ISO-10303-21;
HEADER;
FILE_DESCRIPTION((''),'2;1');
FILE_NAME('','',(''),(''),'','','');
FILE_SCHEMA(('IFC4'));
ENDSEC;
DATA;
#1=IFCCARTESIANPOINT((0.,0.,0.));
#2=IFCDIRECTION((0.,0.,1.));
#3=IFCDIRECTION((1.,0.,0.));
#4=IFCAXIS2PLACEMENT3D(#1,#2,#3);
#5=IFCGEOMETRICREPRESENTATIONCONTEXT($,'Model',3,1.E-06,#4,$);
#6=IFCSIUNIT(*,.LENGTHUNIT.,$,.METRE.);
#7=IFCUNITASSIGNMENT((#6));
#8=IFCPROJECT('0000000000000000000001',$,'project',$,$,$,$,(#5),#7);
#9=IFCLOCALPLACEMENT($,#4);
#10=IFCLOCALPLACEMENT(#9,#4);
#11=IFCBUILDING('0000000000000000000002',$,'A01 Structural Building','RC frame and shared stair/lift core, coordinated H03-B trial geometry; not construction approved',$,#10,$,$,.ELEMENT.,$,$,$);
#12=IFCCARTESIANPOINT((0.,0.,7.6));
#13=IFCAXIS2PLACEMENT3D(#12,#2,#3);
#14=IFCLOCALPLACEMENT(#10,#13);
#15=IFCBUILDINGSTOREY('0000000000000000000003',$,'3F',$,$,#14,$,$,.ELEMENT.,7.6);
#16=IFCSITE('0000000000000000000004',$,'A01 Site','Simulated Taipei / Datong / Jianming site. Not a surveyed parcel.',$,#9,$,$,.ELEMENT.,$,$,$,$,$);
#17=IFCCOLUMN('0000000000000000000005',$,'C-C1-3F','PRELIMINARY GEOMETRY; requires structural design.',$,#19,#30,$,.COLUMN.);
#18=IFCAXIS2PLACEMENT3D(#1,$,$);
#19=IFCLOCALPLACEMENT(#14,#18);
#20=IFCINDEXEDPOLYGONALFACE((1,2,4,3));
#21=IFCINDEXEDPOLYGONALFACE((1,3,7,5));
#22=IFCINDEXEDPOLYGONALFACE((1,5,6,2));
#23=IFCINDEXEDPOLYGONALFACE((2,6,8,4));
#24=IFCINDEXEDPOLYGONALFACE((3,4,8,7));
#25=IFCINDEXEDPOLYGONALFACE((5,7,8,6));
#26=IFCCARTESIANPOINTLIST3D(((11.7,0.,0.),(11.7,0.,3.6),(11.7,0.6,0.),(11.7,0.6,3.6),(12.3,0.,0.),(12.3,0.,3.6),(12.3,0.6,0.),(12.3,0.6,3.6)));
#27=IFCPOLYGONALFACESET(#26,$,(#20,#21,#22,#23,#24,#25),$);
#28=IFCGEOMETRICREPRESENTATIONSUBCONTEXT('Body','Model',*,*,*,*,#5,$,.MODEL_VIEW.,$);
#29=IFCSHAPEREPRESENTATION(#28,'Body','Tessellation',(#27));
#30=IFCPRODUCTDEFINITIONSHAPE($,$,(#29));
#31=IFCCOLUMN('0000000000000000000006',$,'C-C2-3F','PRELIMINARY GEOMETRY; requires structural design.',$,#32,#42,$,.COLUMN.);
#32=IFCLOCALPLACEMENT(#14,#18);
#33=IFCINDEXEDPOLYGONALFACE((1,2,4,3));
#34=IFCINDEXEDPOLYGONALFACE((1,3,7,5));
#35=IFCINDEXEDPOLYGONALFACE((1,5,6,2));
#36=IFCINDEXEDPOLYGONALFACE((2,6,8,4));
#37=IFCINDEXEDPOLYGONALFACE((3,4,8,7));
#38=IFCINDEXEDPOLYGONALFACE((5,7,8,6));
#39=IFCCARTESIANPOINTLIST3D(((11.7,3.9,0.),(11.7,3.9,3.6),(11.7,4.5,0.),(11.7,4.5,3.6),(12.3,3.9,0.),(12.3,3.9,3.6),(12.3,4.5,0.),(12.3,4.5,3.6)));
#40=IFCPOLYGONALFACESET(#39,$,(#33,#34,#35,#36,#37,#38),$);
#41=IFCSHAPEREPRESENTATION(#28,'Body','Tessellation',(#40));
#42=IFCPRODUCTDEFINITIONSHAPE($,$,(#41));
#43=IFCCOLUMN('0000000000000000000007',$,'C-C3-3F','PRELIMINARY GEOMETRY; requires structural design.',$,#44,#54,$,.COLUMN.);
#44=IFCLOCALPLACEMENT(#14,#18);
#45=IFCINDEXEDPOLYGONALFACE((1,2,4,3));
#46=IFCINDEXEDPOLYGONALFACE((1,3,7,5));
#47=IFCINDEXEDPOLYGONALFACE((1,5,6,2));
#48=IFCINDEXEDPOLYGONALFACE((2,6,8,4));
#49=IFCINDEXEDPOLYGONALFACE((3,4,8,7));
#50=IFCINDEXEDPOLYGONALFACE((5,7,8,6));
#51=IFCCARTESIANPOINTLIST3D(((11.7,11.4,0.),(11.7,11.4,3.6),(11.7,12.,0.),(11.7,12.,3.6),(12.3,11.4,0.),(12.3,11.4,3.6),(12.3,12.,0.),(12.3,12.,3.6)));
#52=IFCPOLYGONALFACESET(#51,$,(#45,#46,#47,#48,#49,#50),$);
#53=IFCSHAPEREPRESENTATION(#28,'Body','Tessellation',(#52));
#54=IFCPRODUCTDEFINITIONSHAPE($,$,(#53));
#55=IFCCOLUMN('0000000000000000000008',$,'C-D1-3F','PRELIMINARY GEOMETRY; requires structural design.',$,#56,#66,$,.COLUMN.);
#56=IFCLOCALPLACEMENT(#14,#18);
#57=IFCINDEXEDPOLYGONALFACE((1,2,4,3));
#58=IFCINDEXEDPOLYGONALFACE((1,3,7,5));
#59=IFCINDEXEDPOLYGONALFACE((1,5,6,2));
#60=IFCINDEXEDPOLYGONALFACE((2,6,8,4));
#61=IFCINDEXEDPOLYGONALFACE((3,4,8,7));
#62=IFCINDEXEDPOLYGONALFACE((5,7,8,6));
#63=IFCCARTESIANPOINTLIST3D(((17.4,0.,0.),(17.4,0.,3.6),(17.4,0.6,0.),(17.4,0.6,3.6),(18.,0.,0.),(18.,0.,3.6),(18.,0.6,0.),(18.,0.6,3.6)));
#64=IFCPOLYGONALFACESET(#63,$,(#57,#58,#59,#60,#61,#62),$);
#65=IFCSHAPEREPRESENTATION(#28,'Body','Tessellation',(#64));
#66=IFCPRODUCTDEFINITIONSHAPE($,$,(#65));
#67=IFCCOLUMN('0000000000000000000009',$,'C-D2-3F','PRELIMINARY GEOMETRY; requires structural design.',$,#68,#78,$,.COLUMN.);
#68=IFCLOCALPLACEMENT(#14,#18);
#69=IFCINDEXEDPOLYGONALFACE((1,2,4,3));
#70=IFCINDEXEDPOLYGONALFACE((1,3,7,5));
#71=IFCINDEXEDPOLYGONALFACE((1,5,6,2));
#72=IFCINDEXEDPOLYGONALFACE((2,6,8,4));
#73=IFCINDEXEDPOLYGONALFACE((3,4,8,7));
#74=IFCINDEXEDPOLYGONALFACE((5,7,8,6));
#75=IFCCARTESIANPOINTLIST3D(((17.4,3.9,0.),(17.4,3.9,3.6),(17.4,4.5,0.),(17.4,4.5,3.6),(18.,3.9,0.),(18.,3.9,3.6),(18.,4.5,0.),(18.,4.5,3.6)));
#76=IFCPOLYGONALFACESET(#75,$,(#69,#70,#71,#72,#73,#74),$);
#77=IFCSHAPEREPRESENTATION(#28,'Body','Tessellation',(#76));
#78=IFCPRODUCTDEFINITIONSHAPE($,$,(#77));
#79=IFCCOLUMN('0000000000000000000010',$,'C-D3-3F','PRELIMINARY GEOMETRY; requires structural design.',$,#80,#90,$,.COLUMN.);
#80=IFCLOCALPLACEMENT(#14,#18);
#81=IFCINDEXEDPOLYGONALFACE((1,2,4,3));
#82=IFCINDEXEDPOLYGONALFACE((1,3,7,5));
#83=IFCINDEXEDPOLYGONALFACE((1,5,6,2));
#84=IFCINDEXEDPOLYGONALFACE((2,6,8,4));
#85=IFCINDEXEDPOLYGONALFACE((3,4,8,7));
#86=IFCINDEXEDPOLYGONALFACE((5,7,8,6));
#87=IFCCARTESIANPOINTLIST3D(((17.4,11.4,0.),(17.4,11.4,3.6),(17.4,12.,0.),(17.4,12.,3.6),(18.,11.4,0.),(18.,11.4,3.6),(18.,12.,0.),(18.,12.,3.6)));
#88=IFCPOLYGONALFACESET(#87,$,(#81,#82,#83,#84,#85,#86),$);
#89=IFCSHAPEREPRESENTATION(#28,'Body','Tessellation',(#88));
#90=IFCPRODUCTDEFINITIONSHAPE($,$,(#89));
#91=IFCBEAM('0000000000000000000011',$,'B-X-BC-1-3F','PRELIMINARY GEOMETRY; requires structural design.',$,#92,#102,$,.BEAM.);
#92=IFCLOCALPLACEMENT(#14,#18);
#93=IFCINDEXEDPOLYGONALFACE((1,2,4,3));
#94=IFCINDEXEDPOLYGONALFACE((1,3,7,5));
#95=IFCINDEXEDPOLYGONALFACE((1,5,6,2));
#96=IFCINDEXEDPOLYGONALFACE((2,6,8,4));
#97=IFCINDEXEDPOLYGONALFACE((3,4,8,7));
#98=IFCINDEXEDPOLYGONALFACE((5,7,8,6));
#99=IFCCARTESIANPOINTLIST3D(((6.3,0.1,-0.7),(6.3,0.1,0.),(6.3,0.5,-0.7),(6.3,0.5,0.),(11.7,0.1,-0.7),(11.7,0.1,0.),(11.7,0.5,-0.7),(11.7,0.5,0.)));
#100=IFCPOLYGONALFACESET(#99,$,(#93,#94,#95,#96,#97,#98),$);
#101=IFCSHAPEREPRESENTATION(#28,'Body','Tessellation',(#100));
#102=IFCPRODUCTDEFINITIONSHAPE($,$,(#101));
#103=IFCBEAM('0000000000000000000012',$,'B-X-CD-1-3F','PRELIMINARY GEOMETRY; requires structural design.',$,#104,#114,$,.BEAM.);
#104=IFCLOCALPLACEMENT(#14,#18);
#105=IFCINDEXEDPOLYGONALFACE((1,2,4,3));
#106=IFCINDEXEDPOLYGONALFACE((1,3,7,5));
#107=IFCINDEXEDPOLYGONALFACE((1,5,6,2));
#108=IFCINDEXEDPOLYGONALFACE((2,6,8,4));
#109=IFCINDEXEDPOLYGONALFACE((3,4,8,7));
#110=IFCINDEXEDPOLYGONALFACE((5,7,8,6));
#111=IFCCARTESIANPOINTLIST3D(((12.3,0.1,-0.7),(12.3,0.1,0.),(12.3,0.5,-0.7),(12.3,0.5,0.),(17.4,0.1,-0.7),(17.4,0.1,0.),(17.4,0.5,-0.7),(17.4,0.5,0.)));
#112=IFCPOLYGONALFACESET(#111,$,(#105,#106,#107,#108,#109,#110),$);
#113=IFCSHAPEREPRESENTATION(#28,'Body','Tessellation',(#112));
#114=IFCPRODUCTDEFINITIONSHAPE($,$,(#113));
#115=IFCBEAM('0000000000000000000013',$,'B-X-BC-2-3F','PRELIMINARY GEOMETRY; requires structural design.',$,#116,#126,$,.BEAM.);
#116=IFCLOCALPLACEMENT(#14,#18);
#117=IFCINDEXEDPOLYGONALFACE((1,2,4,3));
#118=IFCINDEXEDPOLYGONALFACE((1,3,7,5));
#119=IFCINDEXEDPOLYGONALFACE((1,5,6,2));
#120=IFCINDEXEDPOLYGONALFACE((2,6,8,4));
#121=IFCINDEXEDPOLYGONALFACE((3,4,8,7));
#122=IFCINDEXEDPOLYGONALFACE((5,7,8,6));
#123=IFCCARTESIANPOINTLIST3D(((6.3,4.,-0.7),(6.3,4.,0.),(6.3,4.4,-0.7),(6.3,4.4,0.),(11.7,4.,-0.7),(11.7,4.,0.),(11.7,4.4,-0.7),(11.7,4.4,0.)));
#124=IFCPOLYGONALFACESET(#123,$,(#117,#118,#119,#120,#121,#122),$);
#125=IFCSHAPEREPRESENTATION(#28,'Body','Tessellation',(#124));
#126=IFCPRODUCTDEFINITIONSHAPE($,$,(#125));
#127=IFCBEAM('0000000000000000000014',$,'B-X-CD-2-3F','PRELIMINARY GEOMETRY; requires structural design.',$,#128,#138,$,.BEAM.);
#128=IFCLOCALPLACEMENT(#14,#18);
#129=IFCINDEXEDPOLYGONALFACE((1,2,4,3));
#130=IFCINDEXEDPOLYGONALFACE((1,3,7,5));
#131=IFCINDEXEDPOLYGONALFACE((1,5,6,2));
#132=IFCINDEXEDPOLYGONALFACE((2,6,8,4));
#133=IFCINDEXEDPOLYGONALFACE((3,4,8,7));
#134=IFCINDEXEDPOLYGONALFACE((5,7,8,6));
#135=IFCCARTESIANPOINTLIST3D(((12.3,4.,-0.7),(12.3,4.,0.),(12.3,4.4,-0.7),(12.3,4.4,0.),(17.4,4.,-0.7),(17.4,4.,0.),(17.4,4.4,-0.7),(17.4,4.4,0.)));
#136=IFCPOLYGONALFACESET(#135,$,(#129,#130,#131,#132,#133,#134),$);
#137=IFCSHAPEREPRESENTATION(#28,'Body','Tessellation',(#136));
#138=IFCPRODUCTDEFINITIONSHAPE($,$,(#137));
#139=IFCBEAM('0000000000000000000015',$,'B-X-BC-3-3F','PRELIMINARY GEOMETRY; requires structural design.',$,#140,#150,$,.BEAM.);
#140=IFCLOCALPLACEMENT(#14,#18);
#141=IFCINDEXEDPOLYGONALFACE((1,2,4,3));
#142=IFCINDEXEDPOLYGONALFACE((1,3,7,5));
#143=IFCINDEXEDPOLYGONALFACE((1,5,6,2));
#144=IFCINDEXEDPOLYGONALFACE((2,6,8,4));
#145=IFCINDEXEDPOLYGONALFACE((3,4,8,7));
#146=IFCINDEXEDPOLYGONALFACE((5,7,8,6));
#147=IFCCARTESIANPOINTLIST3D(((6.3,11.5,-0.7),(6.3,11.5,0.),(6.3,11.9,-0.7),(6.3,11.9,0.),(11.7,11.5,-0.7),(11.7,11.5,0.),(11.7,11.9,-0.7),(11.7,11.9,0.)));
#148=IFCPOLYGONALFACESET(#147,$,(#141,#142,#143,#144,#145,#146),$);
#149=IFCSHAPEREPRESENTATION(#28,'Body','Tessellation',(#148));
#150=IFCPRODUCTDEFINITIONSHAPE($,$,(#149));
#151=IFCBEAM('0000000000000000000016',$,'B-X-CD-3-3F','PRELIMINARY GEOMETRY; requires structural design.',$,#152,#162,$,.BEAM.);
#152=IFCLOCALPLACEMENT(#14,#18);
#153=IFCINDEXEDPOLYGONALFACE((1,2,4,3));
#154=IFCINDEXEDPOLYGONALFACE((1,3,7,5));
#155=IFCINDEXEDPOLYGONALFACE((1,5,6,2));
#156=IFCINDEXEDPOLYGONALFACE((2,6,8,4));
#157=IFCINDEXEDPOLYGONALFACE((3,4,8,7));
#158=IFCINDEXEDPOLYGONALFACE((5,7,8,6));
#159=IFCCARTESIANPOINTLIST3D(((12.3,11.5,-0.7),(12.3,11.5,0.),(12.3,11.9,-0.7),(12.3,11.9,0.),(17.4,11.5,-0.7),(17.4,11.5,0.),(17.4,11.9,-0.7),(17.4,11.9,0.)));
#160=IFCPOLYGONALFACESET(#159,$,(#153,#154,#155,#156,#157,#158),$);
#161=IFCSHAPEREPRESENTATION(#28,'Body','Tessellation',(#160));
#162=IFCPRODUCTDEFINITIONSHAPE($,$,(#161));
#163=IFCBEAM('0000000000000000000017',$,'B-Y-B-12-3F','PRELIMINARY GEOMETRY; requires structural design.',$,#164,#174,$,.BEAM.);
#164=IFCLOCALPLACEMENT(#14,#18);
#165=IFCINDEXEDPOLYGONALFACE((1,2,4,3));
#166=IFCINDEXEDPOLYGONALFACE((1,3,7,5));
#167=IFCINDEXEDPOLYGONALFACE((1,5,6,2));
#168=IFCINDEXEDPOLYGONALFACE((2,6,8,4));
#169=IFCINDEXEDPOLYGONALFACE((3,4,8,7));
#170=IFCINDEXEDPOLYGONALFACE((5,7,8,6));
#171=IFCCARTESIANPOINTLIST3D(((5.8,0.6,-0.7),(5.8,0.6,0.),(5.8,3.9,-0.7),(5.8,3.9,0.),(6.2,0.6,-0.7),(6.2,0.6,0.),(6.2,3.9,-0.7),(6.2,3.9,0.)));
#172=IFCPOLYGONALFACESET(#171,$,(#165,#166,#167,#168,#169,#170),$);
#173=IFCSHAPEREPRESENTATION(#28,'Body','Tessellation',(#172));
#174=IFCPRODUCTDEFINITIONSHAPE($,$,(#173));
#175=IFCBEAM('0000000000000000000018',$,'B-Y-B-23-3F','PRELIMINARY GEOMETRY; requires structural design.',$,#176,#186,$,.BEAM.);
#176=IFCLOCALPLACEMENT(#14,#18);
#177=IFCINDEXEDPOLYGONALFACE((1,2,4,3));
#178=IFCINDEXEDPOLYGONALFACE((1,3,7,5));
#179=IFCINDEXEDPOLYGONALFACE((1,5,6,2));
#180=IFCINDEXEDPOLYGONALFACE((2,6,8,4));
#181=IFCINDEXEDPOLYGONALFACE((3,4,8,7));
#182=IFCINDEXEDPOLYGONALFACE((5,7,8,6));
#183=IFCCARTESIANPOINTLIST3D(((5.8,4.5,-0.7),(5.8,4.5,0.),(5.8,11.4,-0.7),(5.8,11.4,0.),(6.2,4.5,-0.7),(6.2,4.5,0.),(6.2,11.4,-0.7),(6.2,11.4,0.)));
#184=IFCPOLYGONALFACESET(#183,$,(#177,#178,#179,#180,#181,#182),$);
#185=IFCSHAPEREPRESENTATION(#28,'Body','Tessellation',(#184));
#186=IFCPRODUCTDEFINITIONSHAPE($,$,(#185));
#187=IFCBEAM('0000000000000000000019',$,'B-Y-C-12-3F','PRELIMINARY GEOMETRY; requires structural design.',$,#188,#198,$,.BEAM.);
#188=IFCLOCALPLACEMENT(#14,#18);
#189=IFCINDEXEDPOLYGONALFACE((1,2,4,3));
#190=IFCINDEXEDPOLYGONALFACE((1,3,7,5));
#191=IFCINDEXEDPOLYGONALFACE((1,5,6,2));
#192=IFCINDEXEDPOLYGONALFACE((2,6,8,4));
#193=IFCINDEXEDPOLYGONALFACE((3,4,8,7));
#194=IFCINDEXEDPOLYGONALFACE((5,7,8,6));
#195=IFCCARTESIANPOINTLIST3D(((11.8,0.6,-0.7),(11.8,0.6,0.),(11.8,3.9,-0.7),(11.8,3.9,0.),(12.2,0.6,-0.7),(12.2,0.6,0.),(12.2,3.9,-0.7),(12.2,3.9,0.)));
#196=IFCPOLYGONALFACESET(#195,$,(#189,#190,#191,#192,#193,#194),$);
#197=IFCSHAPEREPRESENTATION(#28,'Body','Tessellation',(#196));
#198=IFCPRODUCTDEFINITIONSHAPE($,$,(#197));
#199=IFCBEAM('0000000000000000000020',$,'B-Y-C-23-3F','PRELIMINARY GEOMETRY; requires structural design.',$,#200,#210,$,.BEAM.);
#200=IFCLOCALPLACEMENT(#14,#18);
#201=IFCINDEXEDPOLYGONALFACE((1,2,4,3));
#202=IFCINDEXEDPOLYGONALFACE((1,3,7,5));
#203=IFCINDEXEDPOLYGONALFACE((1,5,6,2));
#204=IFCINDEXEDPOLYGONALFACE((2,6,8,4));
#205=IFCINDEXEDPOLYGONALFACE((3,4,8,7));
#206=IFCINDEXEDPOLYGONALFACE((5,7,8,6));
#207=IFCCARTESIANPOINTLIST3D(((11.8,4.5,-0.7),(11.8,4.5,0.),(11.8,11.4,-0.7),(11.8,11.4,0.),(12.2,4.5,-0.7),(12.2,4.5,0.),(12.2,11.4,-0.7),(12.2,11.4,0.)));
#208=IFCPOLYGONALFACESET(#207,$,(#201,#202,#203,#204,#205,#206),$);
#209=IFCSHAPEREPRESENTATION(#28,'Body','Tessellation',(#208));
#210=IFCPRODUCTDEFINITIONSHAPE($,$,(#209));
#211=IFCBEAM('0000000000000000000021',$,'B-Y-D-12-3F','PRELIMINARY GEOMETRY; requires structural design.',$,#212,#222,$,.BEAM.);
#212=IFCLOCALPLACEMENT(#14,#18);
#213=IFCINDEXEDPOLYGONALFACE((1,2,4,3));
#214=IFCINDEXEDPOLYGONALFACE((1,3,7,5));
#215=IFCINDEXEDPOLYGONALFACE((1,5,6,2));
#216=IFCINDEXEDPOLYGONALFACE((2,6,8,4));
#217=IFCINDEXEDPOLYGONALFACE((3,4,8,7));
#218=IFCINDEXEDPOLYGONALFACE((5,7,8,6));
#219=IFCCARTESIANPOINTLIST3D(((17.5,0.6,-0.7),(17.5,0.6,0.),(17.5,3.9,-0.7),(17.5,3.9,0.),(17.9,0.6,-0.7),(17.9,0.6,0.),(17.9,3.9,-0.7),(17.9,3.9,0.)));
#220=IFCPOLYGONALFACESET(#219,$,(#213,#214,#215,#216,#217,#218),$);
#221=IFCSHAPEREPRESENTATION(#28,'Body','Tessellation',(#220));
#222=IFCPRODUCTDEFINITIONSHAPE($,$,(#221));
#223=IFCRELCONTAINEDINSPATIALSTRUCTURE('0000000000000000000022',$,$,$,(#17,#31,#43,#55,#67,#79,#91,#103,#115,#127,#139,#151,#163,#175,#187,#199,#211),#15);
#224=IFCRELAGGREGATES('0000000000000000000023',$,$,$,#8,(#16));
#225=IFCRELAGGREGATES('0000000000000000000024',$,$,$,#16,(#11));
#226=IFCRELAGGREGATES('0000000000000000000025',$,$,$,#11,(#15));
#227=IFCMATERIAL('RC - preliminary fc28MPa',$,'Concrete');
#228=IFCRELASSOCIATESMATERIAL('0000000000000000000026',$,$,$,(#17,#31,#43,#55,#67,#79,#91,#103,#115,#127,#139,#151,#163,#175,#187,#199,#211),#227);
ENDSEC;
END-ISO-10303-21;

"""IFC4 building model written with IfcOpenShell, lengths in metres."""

from ifc_helpers import new_model, si_unit, frame, origin_with_axes, place, context, subcontext, project, spatial, rectangle, extrude, material, element, save


model = new_model("IFC4")

# Units and contexts
model_context = context("Model", 3, precision=1e-06, world=origin_with_axes())
body_context = subcontext(model_context, "Body", "Model", "MODEL_VIEW")
ifc_project = project(units=[si_unit("LENGTHUNIT", "METRE")], contexts=[model_context])

# Site, building, storey
site_placement = place(None, origin_with_axes())
site = spatial("IfcSite", under=ifc_project, at=site_placement, Name="A01 Site", Description="Simulated Taipei / Datong / Jianming site. Not a surveyed parcel.", CompositionType="ELEMENT")
building_placement = place(site_placement, origin_with_axes())
building = spatial("IfcBuilding", under=site, at=building_placement, Name="A01 Structural Building", Description="RC frame and shared stair/lift core, coordinated H03-B trial geometry; not construction approved", CompositionType="ELEMENT")
storey_placement = place(building_placement, frame((0.0, 0.0, 7.6), z_axis=(0.0, 0.0, 1.0), x_axis=(1.0, 0.0, 0.0)))
storey = spatial("IfcBuildingStorey", under=building, at=storey_placement, Name="3F", CompositionType="ELEMENT", Elevation=7.6)

# Columns
ifc_material = material(Name="RC - preliminary fc28MPa", Category="Concrete")
for number, where, z_axis, x_axis, name in (
    (1, (12.0, 0.3, 0.0), (0.0, 0.0, 1.0), (1.0, 0.0, 0.0), "C-C1-3F"),
    (2, (12.0, 4.2, 0.0), (0.0, 0.0, 1.0), (1.0, 0.0, 0.0), "C-C2-3F"),
    (3, (12.0, 11.7, 0.0), (0.0, 0.0, 1.0), (1.0, 0.0, 0.0), "C-C3-3F"),
    (4, (17.7, 0.3, 0.0), (0.0, 0.0, 1.0), (1.0, 0.0, 0.0), "C-D1-3F"),
    (5, (17.7, 4.2, 0.0), (0.0, 0.0, 1.0), (1.0, 0.0, 0.0), "C-D2-3F"),
    (6, (17.7, 11.7, 0.0), (0.0, 0.0, 1.0), (1.0, 0.0, 0.0), "C-D3-3F"),
):
    element("IfcColumn", number, at=place(storey_placement, frame(where, z_axis=z_axis, x_axis=x_axis)), inside=storey, material=ifc_material, Name=name, Description="PRELIMINARY GEOMETRY; requires structural design.", PredefinedType="COLUMN", context=body_context, shape_type="SweptSolid", body=[
        extrude(rectangle(XDim=0.6, YDim=0.6), origin_with_axes(), (0.0, 0.0, 1.0), 3.6),
    ])

# Beams
beam_1_placement = place(storey_placement, frame((9.0, 0.3, -0.7), z_axis=(0.0, 0.0, 1.0), x_axis=(1.0, 0.0, 0.0)))
element("IfcBeam", 7, at=beam_1_placement, inside=storey, material=ifc_material, Name="B-X-BC-1-3F", Description="PRELIMINARY GEOMETRY; requires structural design.", PredefinedType="BEAM", context=body_context, shape_type="SweptSolid", body=[
    extrude(rectangle(XDim=5.4, YDim=0.4), origin_with_axes(), (0.0, 0.0, 1.0), 0.7),
])
beam_2_placement = place(storey_placement, frame((14.85, 0.3, -0.7), z_axis=(0.0, 0.0, 1.0), x_axis=(1.0, 0.0, 0.0)))
element("IfcBeam", 8, at=beam_2_placement, inside=storey, material=ifc_material, Name="B-X-CD-1-3F", Description="PRELIMINARY GEOMETRY; requires structural design.", PredefinedType="BEAM", context=body_context, shape_type="SweptSolid", body=[
    extrude(rectangle(XDim=5.1, YDim=0.4), origin_with_axes(), (0.0, 0.0, 1.0), 0.7),
])
beam_3_placement = place(storey_placement, frame((9.0, 4.2, -0.7), z_axis=(0.0, 0.0, 1.0), x_axis=(1.0, 0.0, 0.0)))
element("IfcBeam", 9, at=beam_3_placement, inside=storey, material=ifc_material, Name="B-X-BC-2-3F", Description="PRELIMINARY GEOMETRY; requires structural design.", PredefinedType="BEAM", context=body_context, shape_type="SweptSolid", body=[
    extrude(rectangle(XDim=5.4, YDim=0.4), origin_with_axes(), (0.0, 0.0, 1.0), 0.7),
])
beam_4_placement = place(storey_placement, frame((14.85, 4.2, -0.7), z_axis=(0.0, 0.0, 1.0), x_axis=(1.0, 0.0, 0.0)))
element("IfcBeam", 10, at=beam_4_placement, inside=storey, material=ifc_material, Name="B-X-CD-2-3F", Description="PRELIMINARY GEOMETRY; requires structural design.", PredefinedType="BEAM", context=body_context, shape_type="SweptSolid", body=[
    extrude(rectangle(XDim=5.1, YDim=0.4), origin_with_axes(), (0.0, 0.0, 1.0), 0.7),
])
beam_5_placement = place(storey_placement, frame((9.0, 11.7, -0.7), z_axis=(0.0, 0.0, 1.0), x_axis=(1.0, 0.0, 0.0)))
element("IfcBeam", 11, at=beam_5_placement, inside=storey, material=ifc_material, Name="B-X-BC-3-3F", Description="PRELIMINARY GEOMETRY; requires structural design.", PredefinedType="BEAM", context=body_context, shape_type="SweptSolid", body=[
    extrude(rectangle(XDim=5.4, YDim=0.4), origin_with_axes(), (0.0, 0.0, 1.0), 0.7),
])
beam_6_placement = place(storey_placement, frame((14.85, 11.7, -0.7), z_axis=(0.0, 0.0, 1.0), x_axis=(1.0, 0.0, 0.0)))
element("IfcBeam", 12, at=beam_6_placement, inside=storey, material=ifc_material, Name="B-X-CD-3-3F", Description="PRELIMINARY GEOMETRY; requires structural design.", PredefinedType="BEAM", context=body_context, shape_type="SweptSolid", body=[
    extrude(rectangle(XDim=5.1, YDim=0.4), origin_with_axes(), (0.0, 0.0, 1.0), 0.7),
])
beam_7_placement = place(storey_placement, frame((6.0, 2.25, -0.7), z_axis=(0.0, 0.0, 1.0), x_axis=(1.0, 0.0, 0.0)))
element("IfcBeam", 13, at=beam_7_placement, inside=storey, material=ifc_material, Name="B-Y-B-12-3F", Description="PRELIMINARY GEOMETRY; requires structural design.", PredefinedType="BEAM", context=body_context, shape_type="SweptSolid", body=[
    extrude(rectangle(XDim=0.4, YDim=3.3), origin_with_axes(), (0.0, 0.0, 1.0), 0.7),
])
beam_8_placement = place(storey_placement, frame((6.0, 7.95, -0.7), z_axis=(0.0, 0.0, 1.0), x_axis=(1.0, 0.0, 0.0)))
element("IfcBeam", 14, at=beam_8_placement, inside=storey, material=ifc_material, Name="B-Y-B-23-3F", Description="PRELIMINARY GEOMETRY; requires structural design.", PredefinedType="BEAM", context=body_context, shape_type="SweptSolid", body=[
    extrude(rectangle(XDim=0.4, YDim=6.9), origin_with_axes(), (0.0, 0.0, 1.0), 0.7),
])
beam_9_placement = place(storey_placement, frame((12.0, 2.25, -0.7), z_axis=(0.0, 0.0, 1.0), x_axis=(1.0, 0.0, 0.0)))
element("IfcBeam", 15, at=beam_9_placement, inside=storey, material=ifc_material, Name="B-Y-C-12-3F", Description="PRELIMINARY GEOMETRY; requires structural design.", PredefinedType="BEAM", context=body_context, shape_type="SweptSolid", body=[
    extrude(rectangle(XDim=0.4, YDim=3.3), origin_with_axes(), (0.0, 0.0, 1.0), 0.7),
])
beam_10_placement = place(storey_placement, frame((12.0, 7.95, -0.7), z_axis=(0.0, 0.0, 1.0), x_axis=(1.0, 0.0, 0.0)))
element("IfcBeam", 16, at=beam_10_placement, inside=storey, material=ifc_material, Name="B-Y-C-23-3F", Description="PRELIMINARY GEOMETRY; requires structural design.", PredefinedType="BEAM", context=body_context, shape_type="SweptSolid", body=[
    extrude(rectangle(XDim=0.4, YDim=6.9), origin_with_axes(), (0.0, 0.0, 1.0), 0.7),
])
beam_11_placement = place(storey_placement, frame((17.7, 2.25, -0.7), z_axis=(0.0, 0.0, 1.0), x_axis=(1.0, 0.0, 0.0)))
element("IfcBeam", 17, at=beam_11_placement, inside=storey, material=ifc_material, Name="B-Y-D-12-3F", Description="PRELIMINARY GEOMETRY; requires structural design.", PredefinedType="BEAM", context=body_context, shape_type="SweptSolid", body=[
    extrude(rectangle(XDim=0.4, YDim=3.3), origin_with_axes(), (0.0, 0.0, 1.0), 0.7),
])

save(model, "model.ifc")
